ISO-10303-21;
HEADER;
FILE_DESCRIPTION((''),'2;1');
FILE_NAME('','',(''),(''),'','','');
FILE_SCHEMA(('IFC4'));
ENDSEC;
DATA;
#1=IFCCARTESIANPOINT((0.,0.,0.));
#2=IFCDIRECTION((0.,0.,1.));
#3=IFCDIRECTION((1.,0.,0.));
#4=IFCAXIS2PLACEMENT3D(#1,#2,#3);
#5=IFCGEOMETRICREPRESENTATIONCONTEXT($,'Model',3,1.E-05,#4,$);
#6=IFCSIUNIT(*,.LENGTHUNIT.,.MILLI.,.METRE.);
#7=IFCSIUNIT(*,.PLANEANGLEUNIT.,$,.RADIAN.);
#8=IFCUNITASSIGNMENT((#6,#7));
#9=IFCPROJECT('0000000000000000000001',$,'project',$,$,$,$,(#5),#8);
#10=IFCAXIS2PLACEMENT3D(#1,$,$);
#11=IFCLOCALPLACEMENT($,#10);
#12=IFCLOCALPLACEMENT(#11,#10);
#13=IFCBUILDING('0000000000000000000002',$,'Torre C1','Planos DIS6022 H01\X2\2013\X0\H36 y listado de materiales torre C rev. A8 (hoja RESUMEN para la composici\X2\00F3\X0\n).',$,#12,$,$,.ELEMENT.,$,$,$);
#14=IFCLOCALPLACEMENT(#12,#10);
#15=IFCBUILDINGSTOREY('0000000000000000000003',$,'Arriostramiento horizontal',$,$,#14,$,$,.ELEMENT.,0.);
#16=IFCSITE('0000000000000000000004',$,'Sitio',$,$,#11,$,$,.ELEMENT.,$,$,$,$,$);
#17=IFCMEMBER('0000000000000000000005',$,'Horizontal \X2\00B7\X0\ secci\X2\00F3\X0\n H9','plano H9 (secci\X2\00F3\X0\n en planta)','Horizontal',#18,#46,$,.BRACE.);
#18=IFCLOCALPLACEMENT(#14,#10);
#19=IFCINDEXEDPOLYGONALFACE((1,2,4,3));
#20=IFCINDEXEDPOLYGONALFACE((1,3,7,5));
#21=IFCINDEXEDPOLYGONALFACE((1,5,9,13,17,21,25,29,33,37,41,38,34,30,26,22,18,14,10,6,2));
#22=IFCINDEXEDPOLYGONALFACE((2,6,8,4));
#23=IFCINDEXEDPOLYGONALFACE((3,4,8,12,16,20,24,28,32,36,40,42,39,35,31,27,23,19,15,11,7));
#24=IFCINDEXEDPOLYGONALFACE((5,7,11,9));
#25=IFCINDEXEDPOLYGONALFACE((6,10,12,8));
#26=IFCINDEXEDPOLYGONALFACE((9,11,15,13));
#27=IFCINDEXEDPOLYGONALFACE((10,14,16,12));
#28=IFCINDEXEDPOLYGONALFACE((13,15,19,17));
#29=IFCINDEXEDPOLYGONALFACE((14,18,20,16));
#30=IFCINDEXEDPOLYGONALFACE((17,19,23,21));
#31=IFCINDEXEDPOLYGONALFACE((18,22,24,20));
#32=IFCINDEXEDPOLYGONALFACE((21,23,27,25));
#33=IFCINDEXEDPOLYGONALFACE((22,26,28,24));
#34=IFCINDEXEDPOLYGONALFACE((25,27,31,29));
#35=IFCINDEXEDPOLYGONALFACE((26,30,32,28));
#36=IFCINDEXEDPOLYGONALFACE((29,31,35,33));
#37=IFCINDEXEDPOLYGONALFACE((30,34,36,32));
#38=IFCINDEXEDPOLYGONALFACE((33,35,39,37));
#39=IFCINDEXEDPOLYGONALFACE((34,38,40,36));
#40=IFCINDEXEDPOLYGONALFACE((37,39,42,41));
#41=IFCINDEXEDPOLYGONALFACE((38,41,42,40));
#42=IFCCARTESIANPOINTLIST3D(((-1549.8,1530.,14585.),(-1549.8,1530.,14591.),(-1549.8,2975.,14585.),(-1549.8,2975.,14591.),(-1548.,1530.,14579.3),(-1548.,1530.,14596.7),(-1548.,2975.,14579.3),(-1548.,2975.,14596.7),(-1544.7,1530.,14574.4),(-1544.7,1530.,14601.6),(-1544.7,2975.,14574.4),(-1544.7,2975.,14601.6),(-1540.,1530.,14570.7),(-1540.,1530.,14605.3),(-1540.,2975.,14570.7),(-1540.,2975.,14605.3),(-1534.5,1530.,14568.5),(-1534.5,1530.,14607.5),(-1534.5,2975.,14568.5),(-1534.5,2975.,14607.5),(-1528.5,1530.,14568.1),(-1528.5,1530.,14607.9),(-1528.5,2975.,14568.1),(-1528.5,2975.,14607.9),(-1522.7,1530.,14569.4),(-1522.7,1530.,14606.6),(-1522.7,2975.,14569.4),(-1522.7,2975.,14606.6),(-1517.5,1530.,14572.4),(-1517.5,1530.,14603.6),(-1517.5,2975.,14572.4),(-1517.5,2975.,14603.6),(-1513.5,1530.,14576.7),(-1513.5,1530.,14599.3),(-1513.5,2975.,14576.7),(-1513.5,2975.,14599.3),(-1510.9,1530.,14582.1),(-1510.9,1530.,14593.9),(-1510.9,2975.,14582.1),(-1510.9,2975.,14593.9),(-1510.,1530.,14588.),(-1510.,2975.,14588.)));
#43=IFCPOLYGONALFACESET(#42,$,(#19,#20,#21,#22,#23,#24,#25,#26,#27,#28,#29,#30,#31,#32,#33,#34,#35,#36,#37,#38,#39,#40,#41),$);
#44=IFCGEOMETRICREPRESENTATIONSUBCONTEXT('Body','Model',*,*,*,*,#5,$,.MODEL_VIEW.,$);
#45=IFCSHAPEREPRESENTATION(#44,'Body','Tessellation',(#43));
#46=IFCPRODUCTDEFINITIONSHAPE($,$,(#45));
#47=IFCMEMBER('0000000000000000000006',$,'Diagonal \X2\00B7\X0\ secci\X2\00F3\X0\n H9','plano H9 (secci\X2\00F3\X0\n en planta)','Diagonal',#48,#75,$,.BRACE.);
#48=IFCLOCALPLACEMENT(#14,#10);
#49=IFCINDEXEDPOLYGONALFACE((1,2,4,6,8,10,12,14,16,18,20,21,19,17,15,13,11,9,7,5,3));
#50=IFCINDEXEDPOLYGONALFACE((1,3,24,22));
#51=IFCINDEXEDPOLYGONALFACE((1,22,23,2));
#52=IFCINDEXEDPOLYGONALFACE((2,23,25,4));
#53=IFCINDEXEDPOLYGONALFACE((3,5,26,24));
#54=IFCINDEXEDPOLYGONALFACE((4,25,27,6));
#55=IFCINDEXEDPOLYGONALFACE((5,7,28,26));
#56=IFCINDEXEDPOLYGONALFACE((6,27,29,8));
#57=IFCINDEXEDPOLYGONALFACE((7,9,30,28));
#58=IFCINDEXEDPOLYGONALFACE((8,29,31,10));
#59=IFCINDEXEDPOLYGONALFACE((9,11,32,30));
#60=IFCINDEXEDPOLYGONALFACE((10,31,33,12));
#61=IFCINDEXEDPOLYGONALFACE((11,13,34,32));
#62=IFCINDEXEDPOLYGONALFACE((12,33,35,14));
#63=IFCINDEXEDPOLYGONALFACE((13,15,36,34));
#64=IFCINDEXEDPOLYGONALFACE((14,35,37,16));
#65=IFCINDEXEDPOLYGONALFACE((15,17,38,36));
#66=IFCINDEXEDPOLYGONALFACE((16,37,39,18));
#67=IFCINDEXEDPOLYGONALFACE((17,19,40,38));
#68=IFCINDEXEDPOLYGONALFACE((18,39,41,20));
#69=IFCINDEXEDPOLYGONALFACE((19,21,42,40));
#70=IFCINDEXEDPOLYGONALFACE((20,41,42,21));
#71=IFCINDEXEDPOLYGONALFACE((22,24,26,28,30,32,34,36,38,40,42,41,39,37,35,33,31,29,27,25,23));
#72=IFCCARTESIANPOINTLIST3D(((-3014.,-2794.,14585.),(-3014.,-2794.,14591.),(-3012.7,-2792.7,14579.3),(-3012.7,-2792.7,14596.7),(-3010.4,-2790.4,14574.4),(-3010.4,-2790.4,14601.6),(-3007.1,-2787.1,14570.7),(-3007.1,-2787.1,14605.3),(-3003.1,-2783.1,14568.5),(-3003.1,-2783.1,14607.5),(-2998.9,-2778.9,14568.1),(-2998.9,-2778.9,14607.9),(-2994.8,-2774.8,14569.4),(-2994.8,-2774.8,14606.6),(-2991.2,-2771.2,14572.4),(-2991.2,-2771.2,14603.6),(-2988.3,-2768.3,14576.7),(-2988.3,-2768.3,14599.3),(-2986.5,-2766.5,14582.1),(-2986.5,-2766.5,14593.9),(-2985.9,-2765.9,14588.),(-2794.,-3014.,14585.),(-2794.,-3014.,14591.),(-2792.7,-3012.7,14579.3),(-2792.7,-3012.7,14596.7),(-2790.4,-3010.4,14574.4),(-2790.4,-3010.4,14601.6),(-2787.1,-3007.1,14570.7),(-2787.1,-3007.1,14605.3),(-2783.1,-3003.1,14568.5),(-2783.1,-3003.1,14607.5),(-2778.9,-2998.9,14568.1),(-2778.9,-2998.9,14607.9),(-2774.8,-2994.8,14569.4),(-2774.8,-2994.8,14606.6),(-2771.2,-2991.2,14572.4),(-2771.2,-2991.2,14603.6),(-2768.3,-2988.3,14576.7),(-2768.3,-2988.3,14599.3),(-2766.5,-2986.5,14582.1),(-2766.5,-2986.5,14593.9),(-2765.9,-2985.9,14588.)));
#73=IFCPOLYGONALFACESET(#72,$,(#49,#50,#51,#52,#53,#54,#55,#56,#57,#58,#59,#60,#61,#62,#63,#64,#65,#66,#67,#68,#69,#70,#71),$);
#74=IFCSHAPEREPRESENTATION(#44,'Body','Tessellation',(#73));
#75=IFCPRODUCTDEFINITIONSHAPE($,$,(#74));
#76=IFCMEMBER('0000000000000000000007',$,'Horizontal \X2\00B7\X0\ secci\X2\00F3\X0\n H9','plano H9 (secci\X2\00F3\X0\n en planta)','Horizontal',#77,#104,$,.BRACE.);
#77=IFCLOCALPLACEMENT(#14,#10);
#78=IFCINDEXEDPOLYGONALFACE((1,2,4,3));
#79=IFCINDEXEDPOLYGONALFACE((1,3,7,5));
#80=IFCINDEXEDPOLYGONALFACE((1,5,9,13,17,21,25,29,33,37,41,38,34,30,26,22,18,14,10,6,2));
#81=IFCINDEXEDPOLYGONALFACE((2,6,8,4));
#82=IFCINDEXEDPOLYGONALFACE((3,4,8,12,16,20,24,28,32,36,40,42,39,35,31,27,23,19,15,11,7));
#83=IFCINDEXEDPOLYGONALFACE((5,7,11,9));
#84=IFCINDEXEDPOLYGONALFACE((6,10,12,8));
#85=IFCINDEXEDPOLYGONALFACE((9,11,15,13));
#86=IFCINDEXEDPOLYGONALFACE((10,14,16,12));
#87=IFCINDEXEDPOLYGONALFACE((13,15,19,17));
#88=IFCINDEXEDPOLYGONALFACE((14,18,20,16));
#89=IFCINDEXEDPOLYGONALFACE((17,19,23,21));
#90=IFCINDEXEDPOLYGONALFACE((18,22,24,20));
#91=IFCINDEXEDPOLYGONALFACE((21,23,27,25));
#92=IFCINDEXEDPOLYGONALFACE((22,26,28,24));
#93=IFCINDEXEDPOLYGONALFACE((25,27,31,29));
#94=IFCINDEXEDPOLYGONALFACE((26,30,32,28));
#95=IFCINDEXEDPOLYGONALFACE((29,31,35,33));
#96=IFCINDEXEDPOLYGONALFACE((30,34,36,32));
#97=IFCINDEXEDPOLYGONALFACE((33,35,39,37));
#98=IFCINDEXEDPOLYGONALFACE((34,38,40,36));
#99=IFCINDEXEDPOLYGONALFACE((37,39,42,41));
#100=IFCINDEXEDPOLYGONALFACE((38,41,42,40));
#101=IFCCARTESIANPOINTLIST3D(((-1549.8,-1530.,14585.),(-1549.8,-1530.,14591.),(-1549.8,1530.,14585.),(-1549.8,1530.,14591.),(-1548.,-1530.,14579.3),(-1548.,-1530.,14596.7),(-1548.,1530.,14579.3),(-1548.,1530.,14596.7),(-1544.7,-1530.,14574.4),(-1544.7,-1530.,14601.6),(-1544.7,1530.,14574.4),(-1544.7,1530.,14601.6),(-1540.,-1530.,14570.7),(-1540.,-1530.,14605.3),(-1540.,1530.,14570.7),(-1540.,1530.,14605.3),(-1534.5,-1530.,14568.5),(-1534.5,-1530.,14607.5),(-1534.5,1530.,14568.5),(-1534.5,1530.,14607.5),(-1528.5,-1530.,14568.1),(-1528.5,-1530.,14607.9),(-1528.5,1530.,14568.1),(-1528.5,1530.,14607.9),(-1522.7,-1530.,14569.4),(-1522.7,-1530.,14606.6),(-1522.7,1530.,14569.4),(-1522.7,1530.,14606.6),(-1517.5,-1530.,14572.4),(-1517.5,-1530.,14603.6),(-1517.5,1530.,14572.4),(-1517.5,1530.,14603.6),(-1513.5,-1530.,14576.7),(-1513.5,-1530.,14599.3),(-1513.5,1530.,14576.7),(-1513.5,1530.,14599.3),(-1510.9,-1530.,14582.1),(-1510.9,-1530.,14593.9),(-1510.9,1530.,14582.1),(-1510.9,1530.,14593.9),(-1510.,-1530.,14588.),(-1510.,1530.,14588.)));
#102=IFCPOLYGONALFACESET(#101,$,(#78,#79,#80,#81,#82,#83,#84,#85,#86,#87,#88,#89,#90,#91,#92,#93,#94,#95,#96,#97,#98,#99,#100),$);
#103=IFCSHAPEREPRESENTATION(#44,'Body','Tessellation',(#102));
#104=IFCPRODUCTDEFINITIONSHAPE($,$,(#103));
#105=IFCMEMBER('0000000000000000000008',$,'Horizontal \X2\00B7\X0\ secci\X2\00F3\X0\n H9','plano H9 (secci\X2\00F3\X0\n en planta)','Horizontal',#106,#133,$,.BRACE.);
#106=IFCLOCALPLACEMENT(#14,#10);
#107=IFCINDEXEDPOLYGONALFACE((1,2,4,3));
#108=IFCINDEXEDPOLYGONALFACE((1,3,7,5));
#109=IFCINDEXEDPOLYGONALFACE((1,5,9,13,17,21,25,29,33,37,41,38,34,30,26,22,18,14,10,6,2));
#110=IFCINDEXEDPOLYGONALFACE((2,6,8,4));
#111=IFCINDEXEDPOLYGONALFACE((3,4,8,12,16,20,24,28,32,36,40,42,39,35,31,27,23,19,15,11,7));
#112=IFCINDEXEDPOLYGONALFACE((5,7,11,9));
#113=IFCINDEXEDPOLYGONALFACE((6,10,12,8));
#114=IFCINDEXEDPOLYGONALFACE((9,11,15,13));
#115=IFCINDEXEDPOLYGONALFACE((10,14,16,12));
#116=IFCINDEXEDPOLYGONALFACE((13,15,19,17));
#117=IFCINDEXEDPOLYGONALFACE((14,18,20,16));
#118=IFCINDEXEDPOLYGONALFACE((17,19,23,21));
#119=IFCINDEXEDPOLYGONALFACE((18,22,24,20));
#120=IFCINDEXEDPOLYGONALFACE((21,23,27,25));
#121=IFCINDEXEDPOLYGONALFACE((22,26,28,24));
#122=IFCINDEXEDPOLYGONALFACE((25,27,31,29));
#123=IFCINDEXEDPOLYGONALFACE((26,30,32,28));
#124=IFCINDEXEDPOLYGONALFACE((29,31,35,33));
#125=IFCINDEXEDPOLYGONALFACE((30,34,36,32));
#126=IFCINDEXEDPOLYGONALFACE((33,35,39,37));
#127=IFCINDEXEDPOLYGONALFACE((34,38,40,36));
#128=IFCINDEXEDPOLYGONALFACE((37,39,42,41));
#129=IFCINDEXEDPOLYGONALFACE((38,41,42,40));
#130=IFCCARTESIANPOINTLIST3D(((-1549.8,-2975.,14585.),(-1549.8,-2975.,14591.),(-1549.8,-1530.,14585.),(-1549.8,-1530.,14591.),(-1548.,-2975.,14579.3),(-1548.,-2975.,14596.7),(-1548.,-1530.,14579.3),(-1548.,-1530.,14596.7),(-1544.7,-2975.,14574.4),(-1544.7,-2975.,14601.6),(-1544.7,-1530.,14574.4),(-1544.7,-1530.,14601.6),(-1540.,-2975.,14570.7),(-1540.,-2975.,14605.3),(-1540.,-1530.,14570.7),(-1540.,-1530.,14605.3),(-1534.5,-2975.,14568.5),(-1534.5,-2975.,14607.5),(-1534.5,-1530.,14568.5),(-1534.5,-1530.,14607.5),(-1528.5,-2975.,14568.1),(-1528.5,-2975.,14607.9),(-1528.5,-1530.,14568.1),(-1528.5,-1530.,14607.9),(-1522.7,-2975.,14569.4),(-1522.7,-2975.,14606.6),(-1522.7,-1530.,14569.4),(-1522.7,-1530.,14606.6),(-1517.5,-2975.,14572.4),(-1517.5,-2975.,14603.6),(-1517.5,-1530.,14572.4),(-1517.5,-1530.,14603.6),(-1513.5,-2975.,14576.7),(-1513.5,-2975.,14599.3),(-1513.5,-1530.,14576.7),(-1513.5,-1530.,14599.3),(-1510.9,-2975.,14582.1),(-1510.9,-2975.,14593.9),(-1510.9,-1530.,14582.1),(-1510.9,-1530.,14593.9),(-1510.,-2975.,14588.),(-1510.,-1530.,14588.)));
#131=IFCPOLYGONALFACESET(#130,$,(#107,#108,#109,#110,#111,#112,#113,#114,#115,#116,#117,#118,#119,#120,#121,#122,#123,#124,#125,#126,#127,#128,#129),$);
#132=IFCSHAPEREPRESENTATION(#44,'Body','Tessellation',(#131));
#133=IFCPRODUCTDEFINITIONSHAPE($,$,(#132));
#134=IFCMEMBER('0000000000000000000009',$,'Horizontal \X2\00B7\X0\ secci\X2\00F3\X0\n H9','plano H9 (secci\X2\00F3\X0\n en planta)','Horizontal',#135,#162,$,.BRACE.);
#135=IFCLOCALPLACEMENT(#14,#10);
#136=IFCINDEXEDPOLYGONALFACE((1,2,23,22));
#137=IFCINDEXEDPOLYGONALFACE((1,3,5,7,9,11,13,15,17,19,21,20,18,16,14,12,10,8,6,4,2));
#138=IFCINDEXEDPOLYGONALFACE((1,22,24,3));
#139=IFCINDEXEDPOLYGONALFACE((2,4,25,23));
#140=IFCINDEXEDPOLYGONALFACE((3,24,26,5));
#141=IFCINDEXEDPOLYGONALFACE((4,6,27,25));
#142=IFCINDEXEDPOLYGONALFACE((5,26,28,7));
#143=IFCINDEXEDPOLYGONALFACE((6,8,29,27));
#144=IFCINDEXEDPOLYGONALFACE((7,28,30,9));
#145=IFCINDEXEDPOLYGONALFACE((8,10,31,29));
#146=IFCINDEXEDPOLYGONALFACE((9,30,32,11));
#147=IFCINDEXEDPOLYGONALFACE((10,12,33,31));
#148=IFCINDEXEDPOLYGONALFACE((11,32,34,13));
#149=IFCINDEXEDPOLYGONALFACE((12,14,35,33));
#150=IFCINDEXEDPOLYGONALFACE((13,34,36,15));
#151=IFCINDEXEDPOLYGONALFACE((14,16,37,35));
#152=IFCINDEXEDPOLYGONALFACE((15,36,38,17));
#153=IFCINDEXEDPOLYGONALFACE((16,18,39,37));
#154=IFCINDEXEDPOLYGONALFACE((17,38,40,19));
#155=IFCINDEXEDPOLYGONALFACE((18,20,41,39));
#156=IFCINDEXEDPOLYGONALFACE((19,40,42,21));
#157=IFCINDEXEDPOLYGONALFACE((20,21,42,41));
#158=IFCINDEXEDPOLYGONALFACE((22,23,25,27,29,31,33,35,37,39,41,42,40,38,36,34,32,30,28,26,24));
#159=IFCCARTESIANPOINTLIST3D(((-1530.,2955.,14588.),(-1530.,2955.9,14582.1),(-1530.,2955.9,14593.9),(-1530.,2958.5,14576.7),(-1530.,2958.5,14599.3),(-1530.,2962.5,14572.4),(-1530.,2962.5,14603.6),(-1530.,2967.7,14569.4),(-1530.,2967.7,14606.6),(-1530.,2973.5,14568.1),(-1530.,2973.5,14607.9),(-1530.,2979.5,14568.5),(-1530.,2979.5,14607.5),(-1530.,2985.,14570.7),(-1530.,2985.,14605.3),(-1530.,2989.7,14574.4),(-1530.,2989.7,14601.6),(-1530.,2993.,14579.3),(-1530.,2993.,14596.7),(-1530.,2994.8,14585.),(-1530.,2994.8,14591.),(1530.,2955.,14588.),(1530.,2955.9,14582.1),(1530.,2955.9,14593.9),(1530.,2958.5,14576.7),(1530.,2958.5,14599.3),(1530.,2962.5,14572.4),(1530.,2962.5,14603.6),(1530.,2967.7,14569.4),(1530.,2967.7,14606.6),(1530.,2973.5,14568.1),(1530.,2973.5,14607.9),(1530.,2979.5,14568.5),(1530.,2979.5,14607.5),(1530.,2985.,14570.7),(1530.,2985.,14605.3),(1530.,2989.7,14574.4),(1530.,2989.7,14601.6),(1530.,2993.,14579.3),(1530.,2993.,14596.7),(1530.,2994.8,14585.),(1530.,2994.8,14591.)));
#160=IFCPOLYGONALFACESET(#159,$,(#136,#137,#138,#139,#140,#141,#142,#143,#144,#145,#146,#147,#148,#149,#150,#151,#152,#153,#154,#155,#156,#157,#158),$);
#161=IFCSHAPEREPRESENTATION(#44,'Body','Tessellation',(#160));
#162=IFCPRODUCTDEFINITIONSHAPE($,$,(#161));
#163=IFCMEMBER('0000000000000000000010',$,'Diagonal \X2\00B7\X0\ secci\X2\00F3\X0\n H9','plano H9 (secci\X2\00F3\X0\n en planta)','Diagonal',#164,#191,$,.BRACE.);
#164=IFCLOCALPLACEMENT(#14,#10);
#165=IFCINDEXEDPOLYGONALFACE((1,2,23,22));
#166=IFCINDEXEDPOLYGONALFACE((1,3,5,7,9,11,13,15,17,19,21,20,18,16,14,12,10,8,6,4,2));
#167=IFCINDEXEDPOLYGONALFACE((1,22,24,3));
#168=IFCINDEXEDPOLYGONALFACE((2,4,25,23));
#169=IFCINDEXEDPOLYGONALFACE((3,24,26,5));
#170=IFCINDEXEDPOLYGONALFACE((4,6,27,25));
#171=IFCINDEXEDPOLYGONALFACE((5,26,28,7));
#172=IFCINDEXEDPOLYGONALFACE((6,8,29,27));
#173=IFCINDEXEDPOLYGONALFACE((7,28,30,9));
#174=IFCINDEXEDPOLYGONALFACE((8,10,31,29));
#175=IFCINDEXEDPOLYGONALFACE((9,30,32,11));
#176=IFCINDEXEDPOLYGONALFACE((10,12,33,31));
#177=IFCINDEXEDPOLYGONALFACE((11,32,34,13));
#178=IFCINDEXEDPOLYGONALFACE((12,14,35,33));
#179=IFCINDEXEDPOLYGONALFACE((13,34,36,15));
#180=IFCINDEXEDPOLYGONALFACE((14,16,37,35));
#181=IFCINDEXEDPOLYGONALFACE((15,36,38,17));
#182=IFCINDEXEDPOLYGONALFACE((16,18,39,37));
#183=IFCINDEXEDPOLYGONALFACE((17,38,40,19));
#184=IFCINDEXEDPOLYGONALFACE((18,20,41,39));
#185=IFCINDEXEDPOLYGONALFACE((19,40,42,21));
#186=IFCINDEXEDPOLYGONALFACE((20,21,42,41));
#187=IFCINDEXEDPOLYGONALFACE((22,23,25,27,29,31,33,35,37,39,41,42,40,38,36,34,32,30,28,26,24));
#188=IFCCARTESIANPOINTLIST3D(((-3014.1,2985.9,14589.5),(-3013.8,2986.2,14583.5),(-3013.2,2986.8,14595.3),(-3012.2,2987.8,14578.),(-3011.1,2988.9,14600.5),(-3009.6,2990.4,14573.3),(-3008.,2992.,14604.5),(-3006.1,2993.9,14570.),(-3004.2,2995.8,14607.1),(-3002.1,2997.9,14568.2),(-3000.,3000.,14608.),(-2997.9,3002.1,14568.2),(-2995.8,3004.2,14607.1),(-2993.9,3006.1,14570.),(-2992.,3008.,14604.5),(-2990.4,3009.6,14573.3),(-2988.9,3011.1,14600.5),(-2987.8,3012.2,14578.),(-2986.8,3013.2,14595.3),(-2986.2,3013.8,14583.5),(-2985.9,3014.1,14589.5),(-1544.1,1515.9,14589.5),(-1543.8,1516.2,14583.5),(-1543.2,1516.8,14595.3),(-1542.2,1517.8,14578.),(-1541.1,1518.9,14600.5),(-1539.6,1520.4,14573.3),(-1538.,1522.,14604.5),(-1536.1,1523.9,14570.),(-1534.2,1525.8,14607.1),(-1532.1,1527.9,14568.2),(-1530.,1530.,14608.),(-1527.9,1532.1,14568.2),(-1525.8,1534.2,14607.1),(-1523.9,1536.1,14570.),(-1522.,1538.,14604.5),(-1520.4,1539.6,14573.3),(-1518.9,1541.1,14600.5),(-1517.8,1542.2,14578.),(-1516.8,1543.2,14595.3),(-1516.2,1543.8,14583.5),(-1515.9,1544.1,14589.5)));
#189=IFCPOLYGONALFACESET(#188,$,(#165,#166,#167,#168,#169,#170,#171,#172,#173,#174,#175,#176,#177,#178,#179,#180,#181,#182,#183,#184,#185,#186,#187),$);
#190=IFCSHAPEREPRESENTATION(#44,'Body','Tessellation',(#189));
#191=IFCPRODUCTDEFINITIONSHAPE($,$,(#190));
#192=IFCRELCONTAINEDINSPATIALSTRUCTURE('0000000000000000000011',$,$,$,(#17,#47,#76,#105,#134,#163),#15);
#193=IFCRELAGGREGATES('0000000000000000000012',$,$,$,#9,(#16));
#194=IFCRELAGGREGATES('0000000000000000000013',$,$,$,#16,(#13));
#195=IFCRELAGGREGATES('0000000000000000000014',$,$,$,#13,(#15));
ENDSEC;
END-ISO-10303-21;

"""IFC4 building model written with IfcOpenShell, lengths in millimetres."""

from ifc_helpers import new_model, si_unit, frame, origin, origin_with_axes, place, context, subcontext, project, spatial, circle, extrude, element, save


model = new_model("IFC4")

# Units and contexts
model_context = context("Model", 3, precision=1e-05, world=origin_with_axes())
body_context = subcontext(model_context, "Body", "Model", "MODEL_VIEW")
ifc_project = project(units=[si_unit("LENGTHUNIT", "METRE", prefix="MILLI"), si_unit("PLANEANGLEUNIT", "RADIAN")], contexts=[model_context])

# Site, building, storey
site_placement = place(None, origin())
site = spatial("IfcSite", under=ifc_project, at=site_placement, Name="Sitio", CompositionType="ELEMENT")
building_placement = place(site_placement, origin())
building = spatial("IfcBuilding", under=site, at=building_placement, Name="Torre C1", Description="Planos DIS6022 H01–H36 y listado de materiales torre C rev. A8 (hoja RESUMEN para la composición).", CompositionType="ELEMENT")
storey_placement = place(building_placement, origin())
storey = spatial("IfcBuildingStorey", under=building, at=storey_placement, Name="Arriostramiento horizontal", CompositionType="ELEMENT", Elevation=0.0)

# Members
member_1_placement = place(storey_placement, frame((-1530.0, 1530.0, 14588.0), z_axis=(0.0, 1.0, 0.0), x_axis=(1.0, 0.0, 0.0)))
element("IfcMember", 1, at=member_1_placement, inside=storey, Name="Horizontal · sección H9", Description="plano H9 (sección en planta)", ObjectType="Horizontal", PredefinedType="BRACE", context=body_context, shape_type="SweptSolid", body=[
    extrude(circle(Radius=20.0), None, (0.0, 0.0, 1.0), 1445.0),
])
member_2_placement = place(storey_placement, frame((-3000.0, -2780.0, 14588.0), z_axis=(0.707107, -0.707107, 0.0), x_axis=(0.707107, 0.707107, 0.0)))
element("IfcMember", 2, at=member_2_placement, inside=storey, Name="Diagonal · sección H9", Description="plano H9 (sección en planta)", ObjectType="Diagonal", PredefinedType="BRACE", context=body_context, shape_type="SweptSolid", body=[
    extrude(circle(Radius=20.0), None, (0.0, 0.0, 1.0), 311.1),
])
member_3_placement = place(storey_placement, frame((-1530.0, 1530.0, 14588.0), z_axis=(0.0, -1.0, 0.0), x_axis=(1.0, 0.0, 0.0)))
element("IfcMember", 3, at=member_3_placement, inside=storey, Name="Horizontal · sección H9", Description="plano H9 (sección en planta)", ObjectType="Horizontal", PredefinedType="BRACE", context=body_context, shape_type="SweptSolid", body=[
    extrude(circle(Radius=20.0), None, (0.0, 0.0, 1.0), 3060.0),
])
member_4_placement = place(storey_placement, frame((-1530.0, -1530.0, 14588.0), z_axis=(0.0, -1.0, 0.0), x_axis=(1.0, 0.0, 0.0)))
element("IfcMember", 4, at=member_4_placement, inside=storey, Name="Horizontal · sección H9", Description="plano H9 (sección en planta)", ObjectType="Horizontal", PredefinedType="BRACE", context=body_context, shape_type="SweptSolid", body=[
    extrude(circle(Radius=20.0), None, (0.0, 0.0, 1.0), 1445.0),
])
member_5_placement = place(storey_placement, frame((-1530.0, 2975.0, 14588.0), z_axis=(1.0, 0.0, 0.0), x_axis=(0.0, -1.0, 0.0)))
element("IfcMember", 5, at=member_5_placement, inside=storey, Name="Horizontal · sección H9", Description="plano H9 (sección en planta)", ObjectType="Horizontal", PredefinedType="BRACE", context=body_context, shape_type="SweptSolid", body=[
    extrude(circle(Radius=20.0), None, (0.0, 0.0, 1.0), 3060.0),
])
for number, where, z_axis, x_axis, name in (
    (6, (-3000.0, 3000.0, 14588.0), (0.707107, -0.707107, 0.0), (0.0, 0.0, 1.0), "Diagonal · sección H9"),
):
    element("IfcMember", number, at=place(storey_placement, frame(where, z_axis=z_axis, x_axis=x_axis)), inside=storey, Name=name, Description="plano H9 (sección en planta)", ObjectType="Diagonal", PredefinedType="BRACE", context=body_context, shape_type="SweptSolid", body=[
        extrude(circle(Radius=20.0), None, (0.0, 0.0, 1.0), 2078.9),
    ])

save(model, "model.ifc")
